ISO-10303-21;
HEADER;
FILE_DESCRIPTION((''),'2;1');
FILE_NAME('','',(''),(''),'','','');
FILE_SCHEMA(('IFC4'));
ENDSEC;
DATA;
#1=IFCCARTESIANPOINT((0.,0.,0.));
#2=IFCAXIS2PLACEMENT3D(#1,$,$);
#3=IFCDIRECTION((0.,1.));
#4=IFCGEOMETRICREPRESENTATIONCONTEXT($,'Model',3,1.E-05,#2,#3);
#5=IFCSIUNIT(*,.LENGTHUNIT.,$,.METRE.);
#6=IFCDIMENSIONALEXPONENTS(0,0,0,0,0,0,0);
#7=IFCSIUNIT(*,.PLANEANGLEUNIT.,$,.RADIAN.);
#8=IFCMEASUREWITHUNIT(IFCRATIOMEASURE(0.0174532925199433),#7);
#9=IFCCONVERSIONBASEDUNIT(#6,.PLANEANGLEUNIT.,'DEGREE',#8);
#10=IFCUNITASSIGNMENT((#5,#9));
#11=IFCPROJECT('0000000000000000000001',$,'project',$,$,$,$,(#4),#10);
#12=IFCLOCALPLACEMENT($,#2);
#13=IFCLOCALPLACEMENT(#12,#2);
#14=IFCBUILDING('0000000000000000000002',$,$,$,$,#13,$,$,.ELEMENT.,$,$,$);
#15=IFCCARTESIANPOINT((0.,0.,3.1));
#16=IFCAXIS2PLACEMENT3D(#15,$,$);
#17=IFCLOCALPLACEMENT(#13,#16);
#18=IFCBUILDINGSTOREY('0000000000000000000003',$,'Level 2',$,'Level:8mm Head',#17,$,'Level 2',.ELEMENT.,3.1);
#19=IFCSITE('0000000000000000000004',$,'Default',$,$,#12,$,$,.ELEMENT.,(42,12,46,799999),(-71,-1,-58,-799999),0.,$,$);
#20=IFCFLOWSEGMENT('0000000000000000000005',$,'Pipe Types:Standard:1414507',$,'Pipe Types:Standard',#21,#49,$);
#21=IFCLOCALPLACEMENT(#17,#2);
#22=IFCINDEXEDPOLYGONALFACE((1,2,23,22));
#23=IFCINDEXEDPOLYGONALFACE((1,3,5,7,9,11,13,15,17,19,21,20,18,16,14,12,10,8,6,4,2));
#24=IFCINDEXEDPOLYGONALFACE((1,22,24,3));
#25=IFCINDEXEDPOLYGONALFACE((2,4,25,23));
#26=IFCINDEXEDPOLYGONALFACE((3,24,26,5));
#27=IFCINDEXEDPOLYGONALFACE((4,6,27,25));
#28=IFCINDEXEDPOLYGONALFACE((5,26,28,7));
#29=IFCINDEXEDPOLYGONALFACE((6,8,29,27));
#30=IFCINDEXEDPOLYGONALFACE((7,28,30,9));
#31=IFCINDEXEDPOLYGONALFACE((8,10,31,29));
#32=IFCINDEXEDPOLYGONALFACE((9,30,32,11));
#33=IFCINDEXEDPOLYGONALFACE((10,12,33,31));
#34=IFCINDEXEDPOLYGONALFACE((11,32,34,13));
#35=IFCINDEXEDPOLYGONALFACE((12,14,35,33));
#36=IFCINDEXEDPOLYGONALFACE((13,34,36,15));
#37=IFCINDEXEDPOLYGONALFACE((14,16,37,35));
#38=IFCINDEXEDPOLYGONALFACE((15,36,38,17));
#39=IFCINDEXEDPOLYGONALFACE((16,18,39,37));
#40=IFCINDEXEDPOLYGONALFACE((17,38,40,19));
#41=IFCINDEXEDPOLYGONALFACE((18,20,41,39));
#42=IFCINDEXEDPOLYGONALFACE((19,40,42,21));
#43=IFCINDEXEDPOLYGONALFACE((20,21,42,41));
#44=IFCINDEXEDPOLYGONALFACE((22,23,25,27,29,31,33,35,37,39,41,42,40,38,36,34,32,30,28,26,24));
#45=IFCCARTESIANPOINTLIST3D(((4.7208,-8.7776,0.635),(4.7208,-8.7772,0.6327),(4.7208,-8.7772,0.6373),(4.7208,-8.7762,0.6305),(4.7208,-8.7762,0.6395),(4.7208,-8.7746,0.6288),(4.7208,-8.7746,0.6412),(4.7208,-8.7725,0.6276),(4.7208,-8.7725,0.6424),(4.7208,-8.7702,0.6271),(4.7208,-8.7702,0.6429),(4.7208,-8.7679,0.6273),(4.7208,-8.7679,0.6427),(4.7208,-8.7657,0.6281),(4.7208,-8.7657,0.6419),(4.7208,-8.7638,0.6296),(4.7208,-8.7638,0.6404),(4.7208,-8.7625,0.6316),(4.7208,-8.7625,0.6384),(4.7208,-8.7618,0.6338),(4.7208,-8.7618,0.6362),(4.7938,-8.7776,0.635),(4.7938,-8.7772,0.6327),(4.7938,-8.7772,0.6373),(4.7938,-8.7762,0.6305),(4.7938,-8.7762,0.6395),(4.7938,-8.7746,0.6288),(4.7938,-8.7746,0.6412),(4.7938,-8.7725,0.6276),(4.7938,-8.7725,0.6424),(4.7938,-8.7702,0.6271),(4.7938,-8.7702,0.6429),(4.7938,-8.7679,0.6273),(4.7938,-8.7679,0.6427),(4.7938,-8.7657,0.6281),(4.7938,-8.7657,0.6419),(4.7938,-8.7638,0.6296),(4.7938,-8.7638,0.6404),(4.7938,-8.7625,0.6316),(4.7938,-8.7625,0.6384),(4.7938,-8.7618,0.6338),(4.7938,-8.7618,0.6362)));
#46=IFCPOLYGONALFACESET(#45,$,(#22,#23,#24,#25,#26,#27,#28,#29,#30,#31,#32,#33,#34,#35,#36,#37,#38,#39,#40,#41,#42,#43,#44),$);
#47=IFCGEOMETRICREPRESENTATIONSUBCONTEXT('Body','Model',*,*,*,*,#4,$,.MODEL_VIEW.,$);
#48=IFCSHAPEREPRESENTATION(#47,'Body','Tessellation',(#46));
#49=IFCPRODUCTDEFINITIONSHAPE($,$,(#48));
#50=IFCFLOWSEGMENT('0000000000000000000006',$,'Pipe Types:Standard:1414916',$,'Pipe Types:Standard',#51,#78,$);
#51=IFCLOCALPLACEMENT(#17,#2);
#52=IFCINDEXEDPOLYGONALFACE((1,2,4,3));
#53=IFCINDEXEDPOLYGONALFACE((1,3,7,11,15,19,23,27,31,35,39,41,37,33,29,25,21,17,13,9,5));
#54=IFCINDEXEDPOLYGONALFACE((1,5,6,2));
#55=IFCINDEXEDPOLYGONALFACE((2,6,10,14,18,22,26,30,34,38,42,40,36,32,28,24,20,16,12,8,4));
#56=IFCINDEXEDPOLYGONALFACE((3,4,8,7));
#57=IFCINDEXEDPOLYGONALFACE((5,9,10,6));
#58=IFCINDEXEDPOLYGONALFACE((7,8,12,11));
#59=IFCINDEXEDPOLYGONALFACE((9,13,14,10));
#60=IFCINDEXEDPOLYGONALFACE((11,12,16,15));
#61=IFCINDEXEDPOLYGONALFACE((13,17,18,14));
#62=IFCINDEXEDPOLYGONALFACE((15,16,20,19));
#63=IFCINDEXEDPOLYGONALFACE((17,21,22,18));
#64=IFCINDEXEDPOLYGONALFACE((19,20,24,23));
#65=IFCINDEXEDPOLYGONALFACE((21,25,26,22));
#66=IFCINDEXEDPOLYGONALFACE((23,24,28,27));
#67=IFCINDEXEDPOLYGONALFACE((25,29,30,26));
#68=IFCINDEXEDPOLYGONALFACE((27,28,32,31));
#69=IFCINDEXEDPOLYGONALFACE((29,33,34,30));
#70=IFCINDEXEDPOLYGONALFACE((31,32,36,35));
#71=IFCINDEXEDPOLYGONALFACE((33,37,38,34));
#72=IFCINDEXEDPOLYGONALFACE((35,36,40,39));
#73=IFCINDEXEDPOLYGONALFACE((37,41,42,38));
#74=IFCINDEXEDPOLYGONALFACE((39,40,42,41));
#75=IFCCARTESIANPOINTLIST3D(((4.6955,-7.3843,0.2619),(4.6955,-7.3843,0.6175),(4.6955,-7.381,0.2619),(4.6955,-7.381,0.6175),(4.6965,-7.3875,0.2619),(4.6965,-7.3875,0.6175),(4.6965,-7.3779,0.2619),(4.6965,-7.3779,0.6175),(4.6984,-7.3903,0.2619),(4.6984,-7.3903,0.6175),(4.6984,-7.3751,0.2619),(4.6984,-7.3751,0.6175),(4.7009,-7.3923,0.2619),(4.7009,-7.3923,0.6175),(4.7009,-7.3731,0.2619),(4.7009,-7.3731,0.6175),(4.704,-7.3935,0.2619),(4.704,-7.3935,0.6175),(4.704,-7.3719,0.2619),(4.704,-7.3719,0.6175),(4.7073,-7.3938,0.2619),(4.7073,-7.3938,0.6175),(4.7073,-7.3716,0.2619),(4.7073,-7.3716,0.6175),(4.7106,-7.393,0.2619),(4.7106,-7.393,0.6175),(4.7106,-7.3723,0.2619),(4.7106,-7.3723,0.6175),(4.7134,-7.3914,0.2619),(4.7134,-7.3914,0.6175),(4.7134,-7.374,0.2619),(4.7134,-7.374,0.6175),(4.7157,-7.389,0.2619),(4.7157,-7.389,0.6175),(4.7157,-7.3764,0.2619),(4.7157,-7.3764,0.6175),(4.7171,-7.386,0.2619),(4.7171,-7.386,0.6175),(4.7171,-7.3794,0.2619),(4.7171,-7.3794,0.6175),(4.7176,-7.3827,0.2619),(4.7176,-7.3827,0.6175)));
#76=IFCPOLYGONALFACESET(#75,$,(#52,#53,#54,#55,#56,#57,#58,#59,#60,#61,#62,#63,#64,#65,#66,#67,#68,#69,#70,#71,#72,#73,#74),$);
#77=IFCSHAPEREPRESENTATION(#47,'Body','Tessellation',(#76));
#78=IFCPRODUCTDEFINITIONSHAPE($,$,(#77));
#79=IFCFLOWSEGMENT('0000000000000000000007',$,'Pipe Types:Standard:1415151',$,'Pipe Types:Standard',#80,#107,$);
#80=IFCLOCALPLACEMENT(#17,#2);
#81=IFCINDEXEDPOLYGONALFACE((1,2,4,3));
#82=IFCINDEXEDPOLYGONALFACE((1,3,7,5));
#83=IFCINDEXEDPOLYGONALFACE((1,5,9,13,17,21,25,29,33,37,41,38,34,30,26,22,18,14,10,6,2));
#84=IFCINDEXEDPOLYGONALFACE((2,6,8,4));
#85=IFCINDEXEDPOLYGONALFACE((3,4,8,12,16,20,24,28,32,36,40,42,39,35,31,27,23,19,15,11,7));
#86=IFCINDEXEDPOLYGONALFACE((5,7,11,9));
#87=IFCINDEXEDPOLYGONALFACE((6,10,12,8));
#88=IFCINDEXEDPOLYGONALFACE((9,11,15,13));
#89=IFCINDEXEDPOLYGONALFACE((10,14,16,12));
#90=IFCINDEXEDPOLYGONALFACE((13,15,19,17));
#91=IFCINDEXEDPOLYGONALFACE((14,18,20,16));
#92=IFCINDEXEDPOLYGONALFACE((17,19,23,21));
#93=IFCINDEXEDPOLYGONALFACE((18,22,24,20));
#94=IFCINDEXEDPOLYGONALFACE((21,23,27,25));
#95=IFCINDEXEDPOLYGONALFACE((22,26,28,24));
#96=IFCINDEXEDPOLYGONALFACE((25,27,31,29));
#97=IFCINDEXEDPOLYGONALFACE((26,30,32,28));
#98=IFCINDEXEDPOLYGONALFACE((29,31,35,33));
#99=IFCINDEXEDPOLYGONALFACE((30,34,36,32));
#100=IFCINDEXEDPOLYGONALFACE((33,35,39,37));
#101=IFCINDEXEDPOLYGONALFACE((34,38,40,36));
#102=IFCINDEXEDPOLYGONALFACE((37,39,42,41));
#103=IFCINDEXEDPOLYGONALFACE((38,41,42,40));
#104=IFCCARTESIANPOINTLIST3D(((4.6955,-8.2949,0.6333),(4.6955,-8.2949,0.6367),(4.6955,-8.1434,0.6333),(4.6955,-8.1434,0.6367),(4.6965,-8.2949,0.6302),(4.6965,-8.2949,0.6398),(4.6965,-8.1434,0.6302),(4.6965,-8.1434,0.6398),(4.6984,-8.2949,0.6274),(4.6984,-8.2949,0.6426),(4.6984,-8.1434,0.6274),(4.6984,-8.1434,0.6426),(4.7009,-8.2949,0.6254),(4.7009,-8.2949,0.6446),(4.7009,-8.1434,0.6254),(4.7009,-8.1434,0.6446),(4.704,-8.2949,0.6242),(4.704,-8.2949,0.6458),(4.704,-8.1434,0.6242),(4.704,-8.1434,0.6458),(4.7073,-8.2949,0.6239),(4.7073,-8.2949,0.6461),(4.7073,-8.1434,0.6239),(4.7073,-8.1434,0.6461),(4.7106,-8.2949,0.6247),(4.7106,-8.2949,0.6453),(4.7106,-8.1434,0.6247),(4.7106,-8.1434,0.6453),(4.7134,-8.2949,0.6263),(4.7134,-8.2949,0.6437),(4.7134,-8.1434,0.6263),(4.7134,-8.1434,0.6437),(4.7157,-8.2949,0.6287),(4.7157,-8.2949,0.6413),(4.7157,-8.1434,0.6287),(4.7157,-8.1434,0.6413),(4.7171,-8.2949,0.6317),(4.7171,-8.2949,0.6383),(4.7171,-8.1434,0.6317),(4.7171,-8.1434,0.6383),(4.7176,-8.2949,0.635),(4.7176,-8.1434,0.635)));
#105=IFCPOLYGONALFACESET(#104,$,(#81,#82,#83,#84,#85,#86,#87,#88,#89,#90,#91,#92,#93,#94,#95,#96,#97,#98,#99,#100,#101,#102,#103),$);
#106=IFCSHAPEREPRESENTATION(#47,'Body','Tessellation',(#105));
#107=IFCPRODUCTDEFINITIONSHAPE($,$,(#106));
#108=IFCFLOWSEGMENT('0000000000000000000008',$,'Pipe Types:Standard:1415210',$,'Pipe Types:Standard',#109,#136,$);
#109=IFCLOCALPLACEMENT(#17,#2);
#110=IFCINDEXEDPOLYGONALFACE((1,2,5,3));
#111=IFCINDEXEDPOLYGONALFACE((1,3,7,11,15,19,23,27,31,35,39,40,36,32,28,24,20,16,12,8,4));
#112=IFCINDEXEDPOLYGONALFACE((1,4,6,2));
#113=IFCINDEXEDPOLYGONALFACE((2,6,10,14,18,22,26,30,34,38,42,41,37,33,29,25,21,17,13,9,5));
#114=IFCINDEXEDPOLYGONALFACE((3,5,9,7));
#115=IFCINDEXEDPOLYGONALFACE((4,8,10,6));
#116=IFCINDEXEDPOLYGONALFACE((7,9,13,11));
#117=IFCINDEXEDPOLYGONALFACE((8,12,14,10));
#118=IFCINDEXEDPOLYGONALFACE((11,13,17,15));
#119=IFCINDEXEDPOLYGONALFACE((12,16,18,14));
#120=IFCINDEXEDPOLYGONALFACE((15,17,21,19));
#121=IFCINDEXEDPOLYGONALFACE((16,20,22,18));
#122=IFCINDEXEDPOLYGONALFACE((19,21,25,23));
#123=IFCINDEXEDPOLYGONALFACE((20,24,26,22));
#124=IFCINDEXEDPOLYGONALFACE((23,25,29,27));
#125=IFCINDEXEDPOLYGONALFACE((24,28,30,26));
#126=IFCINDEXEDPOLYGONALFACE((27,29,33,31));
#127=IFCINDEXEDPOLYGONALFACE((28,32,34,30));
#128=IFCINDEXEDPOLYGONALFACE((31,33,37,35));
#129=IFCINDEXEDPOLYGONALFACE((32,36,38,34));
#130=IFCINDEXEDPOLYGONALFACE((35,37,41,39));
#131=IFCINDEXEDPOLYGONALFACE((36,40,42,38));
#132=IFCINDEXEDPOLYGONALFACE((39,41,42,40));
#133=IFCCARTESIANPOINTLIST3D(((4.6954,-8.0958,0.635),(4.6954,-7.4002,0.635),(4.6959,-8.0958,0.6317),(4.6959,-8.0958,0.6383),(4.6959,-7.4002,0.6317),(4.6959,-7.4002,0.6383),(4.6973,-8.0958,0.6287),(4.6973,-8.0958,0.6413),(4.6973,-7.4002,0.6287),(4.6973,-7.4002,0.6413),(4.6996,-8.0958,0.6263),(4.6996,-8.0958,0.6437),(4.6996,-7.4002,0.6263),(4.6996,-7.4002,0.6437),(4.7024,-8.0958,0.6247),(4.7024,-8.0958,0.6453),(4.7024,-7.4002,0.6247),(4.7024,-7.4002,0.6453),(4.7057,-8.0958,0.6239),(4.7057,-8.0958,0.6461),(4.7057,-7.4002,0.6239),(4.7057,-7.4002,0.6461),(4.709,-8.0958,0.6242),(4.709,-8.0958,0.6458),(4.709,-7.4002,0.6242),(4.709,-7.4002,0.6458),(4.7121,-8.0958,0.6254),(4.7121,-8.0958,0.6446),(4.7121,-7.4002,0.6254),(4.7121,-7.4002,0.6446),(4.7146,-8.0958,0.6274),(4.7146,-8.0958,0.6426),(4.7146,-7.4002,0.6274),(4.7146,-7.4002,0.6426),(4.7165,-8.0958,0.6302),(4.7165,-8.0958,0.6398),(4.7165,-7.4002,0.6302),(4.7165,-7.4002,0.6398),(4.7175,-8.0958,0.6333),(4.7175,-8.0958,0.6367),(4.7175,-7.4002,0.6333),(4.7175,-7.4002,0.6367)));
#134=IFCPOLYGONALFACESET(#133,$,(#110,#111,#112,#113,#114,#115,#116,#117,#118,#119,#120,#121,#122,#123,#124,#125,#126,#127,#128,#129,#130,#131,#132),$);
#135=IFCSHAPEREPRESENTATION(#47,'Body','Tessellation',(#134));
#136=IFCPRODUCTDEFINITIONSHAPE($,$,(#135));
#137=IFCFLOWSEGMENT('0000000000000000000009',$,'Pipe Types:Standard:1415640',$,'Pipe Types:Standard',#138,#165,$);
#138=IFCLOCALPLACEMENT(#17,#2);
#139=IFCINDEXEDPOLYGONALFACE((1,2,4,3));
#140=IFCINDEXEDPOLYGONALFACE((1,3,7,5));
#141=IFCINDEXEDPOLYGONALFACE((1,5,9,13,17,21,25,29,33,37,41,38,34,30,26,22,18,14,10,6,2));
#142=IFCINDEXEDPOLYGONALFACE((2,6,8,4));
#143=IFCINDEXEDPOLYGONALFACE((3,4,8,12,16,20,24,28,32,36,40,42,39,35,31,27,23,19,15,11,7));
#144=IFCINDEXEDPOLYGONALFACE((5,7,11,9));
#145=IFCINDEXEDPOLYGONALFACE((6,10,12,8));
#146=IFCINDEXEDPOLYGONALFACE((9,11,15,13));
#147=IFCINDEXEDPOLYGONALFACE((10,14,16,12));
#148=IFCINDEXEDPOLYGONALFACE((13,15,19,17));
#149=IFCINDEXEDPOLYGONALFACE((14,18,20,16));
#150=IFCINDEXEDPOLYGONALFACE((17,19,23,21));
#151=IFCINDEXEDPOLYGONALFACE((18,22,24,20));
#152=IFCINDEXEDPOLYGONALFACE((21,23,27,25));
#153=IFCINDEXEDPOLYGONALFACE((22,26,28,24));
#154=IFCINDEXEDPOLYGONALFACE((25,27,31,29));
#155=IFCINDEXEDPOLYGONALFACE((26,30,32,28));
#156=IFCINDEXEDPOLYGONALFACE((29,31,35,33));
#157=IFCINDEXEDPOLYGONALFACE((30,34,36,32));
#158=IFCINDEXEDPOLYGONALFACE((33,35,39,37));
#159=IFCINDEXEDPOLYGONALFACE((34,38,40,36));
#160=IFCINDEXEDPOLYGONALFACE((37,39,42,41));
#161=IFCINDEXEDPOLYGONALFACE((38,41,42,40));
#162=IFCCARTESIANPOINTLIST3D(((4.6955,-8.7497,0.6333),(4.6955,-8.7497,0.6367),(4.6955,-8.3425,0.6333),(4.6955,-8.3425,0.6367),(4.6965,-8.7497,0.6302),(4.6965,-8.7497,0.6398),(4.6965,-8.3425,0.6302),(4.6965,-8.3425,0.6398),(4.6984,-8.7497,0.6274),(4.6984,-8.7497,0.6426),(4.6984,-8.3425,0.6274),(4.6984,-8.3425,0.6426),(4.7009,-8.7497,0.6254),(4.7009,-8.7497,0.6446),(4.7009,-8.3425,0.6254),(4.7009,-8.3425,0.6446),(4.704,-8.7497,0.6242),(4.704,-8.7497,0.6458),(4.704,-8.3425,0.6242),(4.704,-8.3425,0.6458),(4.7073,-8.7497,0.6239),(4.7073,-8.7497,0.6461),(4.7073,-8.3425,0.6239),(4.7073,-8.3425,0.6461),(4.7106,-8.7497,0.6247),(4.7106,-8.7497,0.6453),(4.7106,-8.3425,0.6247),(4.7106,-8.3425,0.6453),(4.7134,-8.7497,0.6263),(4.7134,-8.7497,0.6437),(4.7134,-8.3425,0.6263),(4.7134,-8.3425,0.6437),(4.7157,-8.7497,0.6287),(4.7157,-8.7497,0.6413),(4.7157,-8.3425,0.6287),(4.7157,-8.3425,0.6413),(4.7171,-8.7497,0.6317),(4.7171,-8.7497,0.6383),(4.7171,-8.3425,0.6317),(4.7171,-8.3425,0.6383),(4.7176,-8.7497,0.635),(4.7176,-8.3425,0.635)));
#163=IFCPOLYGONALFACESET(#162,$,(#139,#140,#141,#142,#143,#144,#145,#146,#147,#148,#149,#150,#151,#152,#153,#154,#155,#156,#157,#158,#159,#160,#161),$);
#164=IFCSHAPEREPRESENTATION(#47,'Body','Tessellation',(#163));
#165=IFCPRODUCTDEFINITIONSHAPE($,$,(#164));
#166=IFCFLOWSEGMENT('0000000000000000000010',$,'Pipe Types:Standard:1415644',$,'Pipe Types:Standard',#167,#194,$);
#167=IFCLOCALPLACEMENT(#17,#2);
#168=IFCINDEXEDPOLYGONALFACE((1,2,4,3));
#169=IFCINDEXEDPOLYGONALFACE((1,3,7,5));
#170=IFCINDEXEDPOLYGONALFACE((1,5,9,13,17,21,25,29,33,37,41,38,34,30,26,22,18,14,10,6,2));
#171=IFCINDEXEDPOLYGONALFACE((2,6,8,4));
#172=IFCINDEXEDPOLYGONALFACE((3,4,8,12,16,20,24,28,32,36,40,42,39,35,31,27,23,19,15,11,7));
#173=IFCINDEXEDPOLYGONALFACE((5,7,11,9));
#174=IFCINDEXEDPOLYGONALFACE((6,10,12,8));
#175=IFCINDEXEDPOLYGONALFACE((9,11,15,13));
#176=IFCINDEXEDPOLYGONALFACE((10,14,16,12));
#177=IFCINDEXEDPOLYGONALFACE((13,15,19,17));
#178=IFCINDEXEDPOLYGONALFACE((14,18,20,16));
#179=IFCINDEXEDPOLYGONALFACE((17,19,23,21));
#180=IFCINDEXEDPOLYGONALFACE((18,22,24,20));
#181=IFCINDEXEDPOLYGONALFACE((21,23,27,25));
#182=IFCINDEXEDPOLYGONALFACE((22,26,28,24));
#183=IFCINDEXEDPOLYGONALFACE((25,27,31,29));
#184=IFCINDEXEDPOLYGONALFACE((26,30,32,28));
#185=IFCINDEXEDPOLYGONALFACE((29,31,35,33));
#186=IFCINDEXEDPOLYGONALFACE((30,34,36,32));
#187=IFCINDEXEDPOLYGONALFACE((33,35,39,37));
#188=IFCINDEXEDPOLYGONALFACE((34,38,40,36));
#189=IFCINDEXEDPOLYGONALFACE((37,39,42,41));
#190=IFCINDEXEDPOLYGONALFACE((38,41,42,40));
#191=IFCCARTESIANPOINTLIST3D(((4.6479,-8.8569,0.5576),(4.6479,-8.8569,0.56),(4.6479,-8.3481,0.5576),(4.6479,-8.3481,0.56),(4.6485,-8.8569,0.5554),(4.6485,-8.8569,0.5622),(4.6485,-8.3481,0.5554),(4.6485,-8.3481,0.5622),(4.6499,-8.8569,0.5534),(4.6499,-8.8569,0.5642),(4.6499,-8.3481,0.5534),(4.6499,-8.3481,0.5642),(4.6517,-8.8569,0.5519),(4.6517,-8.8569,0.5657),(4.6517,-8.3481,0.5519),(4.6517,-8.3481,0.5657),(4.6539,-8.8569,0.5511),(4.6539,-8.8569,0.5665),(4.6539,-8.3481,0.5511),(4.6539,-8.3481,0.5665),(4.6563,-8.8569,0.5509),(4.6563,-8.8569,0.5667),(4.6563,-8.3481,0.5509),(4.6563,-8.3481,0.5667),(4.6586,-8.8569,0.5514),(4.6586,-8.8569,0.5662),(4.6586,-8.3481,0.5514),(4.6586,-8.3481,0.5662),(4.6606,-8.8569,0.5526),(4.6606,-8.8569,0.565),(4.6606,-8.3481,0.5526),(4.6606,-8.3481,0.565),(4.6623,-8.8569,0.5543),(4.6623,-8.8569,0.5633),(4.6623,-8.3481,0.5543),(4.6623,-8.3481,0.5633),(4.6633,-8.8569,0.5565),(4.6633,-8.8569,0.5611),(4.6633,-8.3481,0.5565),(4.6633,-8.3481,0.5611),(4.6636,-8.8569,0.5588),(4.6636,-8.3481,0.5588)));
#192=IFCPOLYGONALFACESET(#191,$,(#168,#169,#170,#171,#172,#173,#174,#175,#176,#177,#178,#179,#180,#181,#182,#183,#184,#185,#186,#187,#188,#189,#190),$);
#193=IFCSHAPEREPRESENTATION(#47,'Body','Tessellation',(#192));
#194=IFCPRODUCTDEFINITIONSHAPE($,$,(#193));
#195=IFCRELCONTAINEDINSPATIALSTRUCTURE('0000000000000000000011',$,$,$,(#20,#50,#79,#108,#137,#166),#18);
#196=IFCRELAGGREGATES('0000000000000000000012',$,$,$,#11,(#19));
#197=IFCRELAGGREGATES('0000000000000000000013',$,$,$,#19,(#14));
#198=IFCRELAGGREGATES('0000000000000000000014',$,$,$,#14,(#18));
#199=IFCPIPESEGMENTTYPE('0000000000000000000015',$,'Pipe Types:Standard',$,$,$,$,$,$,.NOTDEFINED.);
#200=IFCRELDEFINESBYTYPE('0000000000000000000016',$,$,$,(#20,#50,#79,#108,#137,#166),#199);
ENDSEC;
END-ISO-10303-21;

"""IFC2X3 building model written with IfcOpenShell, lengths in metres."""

from ifc_helpers import new_model, entity, si_unit, converted_unit, direction, frame, frame_2d, origin, origin_2d_with_axis, place, context, subcontext, project, spatial, circle, extrude, type_object, element, save


model = new_model("IFC2X3")

# Units and contexts
model_context = context("Model", 3, precision=1e-05, world=origin(), true_north=direction((0.0, 1.0)))
body_context = subcontext(model_context, "Body", "Model", "MODEL_VIEW")
ifc_project = project(units=[si_unit("LENGTHUNIT", "METRE"), converted_unit("PLANEANGLEUNIT", "DEGREE", entity("IfcRatioMeasure", 0.0174532925199433), si_unit("PLANEANGLEUNIT", "RADIAN"), dimensions=[0, 0, 0, 0, 0, 0, 0])], contexts=[model_context])

# Site, building, storey
site_placement = place(None, origin())
site = spatial("IfcSite", under=ifc_project, at=site_placement, Name="Default", CompositionType="ELEMENT", RefLatitude=(42, 12, 46, 799999), RefLongitude=(-71, -1, -58, -799999), RefElevation=0.0)
building_placement = place(site_placement, origin())
building = spatial("IfcBuilding", under=site, at=building_placement, CompositionType="ELEMENT")
storey_placement = place(building_placement, frame((0.0, 0.0, 3.1)))
storey = spatial("IfcBuildingStorey", under=building, at=storey_placement, Name="Level 2", ObjectType="Level:8mm Head", LongName="Level 2", CompositionType="ELEMENT", Elevation=3.1)

# Flow segments
pipe_segment_type = type_object("IfcPipeSegmentType", Name="Pipe Types:Standard", PredefinedType="NOTDEFINED")
flow_segment_1_placement = place(storey_placement, origin())
element("IfcFlowSegment", 1, at=flow_segment_1_placement, inside=storey, type_object=pipe_segment_type, Name="Pipe Types:Standard:1414507", ObjectType="Pipe Types:Standard", context=body_context, shape_type="SweptSolid", body=[
    extrude(circle(Radius=0.0079, at=origin_2d_with_axis()), frame((4.7208, -8.7696, 0.635), z_axis=(1.0, 0.0, 0.0), x_axis=(0.0, -1.0, 0.0)), (0.0, 0.0, 1.0), 0.073),
])
flow_segment_2_placement = place(storey_placement, origin())
element("IfcFlowSegment", 2, at=flow_segment_2_placement, inside=storey, type_object=pipe_segment_type, Name="Pipe Types:Standard:1414916", ObjectType="Pipe Types:Standard", context=body_context, shape_type="SweptSolid", body=[
    extrude(circle(Radius=0.0111, at=origin_2d_with_axis()), frame((4.7065, -7.3827, 0.2619)), (0.0, 0.0, 1.0), 0.3557),
])
flow_segment_3_placement = place(storey_placement, origin())
element("IfcFlowSegment", 3, at=flow_segment_3_placement, inside=storey, type_object=pipe_segment_type, Name="Pipe Types:Standard:1415151", ObjectType="Pipe Types:Standard", context=body_context, shape_type="SweptSolid", body=[
    extrude(circle(Radius=0.0111, at=frame_2d((0.0, 0.0), x_axis=(1.0, 0.0))), frame((4.7065, -8.2949, 0.635), z_axis=(0.0, 1.0, 0.0), x_axis=(1.0, 0.0, 0.0)), (0.0, 0.0, 1.0), 0.1515),
])
flow_segment_4_placement = place(storey_placement, origin())
element("IfcFlowSegment", 4, at=flow_segment_4_placement, inside=storey, type_object=pipe_segment_type, Name="Pipe Types:Standard:1415210", ObjectType="Pipe Types:Standard", context=body_context, shape_type="SweptSolid", body=[
    extrude(circle(Radius=0.0111, at=frame_2d((0.0, 0.0), x_axis=(1.0, 0.0))), frame((4.7065, -8.0958, 0.635), z_axis=(0.0, 1.0, 0.0), x_axis=(-1.0, 0.0, 0.0)), (0.0, 0.0, 1.0), 0.6956),
])
flow_segment_5_placement = place(storey_placement, origin())
element("IfcFlowSegment", 5, at=flow_segment_5_placement, inside=storey, type_object=pipe_segment_type, Name="Pipe Types:Standard:1415640", ObjectType="Pipe Types:Standard", context=body_context, shape_type="SweptSolid", body=[
    extrude(circle(Radius=0.0111, at=frame_2d((0.0, 0.0), x_axis=(1.0, 0.0))), frame((4.7065, -8.7497, 0.635), z_axis=(0.0, 1.0, 0.0), x_axis=(1.0, 0.0, 0.0)), (0.0, 0.0, 1.0), 0.4072),
])
flow_segment_6_placement = place(storey_placement, origin())
element("IfcFlowSegment", 6, at=flow_segment_6_placement, inside=storey, type_object=pipe_segment_type, Name="Pipe Types:Standard:1415644", ObjectType="Pipe Types:Standard", context=body_context, shape_type="SweptSolid", body=[
    extrude(circle(Radius=0.0079, at=frame_2d((0.0, 0.0), x_axis=(1.0, 0.0))), frame((4.6557, -8.8569, 0.5588), z_axis=(0.0, 1.0, 0.0), x_axis=(1.0, 0.0, 0.0)), (0.0, 0.0, 1.0), 0.5088),
])

save(model, "model.ifc")
